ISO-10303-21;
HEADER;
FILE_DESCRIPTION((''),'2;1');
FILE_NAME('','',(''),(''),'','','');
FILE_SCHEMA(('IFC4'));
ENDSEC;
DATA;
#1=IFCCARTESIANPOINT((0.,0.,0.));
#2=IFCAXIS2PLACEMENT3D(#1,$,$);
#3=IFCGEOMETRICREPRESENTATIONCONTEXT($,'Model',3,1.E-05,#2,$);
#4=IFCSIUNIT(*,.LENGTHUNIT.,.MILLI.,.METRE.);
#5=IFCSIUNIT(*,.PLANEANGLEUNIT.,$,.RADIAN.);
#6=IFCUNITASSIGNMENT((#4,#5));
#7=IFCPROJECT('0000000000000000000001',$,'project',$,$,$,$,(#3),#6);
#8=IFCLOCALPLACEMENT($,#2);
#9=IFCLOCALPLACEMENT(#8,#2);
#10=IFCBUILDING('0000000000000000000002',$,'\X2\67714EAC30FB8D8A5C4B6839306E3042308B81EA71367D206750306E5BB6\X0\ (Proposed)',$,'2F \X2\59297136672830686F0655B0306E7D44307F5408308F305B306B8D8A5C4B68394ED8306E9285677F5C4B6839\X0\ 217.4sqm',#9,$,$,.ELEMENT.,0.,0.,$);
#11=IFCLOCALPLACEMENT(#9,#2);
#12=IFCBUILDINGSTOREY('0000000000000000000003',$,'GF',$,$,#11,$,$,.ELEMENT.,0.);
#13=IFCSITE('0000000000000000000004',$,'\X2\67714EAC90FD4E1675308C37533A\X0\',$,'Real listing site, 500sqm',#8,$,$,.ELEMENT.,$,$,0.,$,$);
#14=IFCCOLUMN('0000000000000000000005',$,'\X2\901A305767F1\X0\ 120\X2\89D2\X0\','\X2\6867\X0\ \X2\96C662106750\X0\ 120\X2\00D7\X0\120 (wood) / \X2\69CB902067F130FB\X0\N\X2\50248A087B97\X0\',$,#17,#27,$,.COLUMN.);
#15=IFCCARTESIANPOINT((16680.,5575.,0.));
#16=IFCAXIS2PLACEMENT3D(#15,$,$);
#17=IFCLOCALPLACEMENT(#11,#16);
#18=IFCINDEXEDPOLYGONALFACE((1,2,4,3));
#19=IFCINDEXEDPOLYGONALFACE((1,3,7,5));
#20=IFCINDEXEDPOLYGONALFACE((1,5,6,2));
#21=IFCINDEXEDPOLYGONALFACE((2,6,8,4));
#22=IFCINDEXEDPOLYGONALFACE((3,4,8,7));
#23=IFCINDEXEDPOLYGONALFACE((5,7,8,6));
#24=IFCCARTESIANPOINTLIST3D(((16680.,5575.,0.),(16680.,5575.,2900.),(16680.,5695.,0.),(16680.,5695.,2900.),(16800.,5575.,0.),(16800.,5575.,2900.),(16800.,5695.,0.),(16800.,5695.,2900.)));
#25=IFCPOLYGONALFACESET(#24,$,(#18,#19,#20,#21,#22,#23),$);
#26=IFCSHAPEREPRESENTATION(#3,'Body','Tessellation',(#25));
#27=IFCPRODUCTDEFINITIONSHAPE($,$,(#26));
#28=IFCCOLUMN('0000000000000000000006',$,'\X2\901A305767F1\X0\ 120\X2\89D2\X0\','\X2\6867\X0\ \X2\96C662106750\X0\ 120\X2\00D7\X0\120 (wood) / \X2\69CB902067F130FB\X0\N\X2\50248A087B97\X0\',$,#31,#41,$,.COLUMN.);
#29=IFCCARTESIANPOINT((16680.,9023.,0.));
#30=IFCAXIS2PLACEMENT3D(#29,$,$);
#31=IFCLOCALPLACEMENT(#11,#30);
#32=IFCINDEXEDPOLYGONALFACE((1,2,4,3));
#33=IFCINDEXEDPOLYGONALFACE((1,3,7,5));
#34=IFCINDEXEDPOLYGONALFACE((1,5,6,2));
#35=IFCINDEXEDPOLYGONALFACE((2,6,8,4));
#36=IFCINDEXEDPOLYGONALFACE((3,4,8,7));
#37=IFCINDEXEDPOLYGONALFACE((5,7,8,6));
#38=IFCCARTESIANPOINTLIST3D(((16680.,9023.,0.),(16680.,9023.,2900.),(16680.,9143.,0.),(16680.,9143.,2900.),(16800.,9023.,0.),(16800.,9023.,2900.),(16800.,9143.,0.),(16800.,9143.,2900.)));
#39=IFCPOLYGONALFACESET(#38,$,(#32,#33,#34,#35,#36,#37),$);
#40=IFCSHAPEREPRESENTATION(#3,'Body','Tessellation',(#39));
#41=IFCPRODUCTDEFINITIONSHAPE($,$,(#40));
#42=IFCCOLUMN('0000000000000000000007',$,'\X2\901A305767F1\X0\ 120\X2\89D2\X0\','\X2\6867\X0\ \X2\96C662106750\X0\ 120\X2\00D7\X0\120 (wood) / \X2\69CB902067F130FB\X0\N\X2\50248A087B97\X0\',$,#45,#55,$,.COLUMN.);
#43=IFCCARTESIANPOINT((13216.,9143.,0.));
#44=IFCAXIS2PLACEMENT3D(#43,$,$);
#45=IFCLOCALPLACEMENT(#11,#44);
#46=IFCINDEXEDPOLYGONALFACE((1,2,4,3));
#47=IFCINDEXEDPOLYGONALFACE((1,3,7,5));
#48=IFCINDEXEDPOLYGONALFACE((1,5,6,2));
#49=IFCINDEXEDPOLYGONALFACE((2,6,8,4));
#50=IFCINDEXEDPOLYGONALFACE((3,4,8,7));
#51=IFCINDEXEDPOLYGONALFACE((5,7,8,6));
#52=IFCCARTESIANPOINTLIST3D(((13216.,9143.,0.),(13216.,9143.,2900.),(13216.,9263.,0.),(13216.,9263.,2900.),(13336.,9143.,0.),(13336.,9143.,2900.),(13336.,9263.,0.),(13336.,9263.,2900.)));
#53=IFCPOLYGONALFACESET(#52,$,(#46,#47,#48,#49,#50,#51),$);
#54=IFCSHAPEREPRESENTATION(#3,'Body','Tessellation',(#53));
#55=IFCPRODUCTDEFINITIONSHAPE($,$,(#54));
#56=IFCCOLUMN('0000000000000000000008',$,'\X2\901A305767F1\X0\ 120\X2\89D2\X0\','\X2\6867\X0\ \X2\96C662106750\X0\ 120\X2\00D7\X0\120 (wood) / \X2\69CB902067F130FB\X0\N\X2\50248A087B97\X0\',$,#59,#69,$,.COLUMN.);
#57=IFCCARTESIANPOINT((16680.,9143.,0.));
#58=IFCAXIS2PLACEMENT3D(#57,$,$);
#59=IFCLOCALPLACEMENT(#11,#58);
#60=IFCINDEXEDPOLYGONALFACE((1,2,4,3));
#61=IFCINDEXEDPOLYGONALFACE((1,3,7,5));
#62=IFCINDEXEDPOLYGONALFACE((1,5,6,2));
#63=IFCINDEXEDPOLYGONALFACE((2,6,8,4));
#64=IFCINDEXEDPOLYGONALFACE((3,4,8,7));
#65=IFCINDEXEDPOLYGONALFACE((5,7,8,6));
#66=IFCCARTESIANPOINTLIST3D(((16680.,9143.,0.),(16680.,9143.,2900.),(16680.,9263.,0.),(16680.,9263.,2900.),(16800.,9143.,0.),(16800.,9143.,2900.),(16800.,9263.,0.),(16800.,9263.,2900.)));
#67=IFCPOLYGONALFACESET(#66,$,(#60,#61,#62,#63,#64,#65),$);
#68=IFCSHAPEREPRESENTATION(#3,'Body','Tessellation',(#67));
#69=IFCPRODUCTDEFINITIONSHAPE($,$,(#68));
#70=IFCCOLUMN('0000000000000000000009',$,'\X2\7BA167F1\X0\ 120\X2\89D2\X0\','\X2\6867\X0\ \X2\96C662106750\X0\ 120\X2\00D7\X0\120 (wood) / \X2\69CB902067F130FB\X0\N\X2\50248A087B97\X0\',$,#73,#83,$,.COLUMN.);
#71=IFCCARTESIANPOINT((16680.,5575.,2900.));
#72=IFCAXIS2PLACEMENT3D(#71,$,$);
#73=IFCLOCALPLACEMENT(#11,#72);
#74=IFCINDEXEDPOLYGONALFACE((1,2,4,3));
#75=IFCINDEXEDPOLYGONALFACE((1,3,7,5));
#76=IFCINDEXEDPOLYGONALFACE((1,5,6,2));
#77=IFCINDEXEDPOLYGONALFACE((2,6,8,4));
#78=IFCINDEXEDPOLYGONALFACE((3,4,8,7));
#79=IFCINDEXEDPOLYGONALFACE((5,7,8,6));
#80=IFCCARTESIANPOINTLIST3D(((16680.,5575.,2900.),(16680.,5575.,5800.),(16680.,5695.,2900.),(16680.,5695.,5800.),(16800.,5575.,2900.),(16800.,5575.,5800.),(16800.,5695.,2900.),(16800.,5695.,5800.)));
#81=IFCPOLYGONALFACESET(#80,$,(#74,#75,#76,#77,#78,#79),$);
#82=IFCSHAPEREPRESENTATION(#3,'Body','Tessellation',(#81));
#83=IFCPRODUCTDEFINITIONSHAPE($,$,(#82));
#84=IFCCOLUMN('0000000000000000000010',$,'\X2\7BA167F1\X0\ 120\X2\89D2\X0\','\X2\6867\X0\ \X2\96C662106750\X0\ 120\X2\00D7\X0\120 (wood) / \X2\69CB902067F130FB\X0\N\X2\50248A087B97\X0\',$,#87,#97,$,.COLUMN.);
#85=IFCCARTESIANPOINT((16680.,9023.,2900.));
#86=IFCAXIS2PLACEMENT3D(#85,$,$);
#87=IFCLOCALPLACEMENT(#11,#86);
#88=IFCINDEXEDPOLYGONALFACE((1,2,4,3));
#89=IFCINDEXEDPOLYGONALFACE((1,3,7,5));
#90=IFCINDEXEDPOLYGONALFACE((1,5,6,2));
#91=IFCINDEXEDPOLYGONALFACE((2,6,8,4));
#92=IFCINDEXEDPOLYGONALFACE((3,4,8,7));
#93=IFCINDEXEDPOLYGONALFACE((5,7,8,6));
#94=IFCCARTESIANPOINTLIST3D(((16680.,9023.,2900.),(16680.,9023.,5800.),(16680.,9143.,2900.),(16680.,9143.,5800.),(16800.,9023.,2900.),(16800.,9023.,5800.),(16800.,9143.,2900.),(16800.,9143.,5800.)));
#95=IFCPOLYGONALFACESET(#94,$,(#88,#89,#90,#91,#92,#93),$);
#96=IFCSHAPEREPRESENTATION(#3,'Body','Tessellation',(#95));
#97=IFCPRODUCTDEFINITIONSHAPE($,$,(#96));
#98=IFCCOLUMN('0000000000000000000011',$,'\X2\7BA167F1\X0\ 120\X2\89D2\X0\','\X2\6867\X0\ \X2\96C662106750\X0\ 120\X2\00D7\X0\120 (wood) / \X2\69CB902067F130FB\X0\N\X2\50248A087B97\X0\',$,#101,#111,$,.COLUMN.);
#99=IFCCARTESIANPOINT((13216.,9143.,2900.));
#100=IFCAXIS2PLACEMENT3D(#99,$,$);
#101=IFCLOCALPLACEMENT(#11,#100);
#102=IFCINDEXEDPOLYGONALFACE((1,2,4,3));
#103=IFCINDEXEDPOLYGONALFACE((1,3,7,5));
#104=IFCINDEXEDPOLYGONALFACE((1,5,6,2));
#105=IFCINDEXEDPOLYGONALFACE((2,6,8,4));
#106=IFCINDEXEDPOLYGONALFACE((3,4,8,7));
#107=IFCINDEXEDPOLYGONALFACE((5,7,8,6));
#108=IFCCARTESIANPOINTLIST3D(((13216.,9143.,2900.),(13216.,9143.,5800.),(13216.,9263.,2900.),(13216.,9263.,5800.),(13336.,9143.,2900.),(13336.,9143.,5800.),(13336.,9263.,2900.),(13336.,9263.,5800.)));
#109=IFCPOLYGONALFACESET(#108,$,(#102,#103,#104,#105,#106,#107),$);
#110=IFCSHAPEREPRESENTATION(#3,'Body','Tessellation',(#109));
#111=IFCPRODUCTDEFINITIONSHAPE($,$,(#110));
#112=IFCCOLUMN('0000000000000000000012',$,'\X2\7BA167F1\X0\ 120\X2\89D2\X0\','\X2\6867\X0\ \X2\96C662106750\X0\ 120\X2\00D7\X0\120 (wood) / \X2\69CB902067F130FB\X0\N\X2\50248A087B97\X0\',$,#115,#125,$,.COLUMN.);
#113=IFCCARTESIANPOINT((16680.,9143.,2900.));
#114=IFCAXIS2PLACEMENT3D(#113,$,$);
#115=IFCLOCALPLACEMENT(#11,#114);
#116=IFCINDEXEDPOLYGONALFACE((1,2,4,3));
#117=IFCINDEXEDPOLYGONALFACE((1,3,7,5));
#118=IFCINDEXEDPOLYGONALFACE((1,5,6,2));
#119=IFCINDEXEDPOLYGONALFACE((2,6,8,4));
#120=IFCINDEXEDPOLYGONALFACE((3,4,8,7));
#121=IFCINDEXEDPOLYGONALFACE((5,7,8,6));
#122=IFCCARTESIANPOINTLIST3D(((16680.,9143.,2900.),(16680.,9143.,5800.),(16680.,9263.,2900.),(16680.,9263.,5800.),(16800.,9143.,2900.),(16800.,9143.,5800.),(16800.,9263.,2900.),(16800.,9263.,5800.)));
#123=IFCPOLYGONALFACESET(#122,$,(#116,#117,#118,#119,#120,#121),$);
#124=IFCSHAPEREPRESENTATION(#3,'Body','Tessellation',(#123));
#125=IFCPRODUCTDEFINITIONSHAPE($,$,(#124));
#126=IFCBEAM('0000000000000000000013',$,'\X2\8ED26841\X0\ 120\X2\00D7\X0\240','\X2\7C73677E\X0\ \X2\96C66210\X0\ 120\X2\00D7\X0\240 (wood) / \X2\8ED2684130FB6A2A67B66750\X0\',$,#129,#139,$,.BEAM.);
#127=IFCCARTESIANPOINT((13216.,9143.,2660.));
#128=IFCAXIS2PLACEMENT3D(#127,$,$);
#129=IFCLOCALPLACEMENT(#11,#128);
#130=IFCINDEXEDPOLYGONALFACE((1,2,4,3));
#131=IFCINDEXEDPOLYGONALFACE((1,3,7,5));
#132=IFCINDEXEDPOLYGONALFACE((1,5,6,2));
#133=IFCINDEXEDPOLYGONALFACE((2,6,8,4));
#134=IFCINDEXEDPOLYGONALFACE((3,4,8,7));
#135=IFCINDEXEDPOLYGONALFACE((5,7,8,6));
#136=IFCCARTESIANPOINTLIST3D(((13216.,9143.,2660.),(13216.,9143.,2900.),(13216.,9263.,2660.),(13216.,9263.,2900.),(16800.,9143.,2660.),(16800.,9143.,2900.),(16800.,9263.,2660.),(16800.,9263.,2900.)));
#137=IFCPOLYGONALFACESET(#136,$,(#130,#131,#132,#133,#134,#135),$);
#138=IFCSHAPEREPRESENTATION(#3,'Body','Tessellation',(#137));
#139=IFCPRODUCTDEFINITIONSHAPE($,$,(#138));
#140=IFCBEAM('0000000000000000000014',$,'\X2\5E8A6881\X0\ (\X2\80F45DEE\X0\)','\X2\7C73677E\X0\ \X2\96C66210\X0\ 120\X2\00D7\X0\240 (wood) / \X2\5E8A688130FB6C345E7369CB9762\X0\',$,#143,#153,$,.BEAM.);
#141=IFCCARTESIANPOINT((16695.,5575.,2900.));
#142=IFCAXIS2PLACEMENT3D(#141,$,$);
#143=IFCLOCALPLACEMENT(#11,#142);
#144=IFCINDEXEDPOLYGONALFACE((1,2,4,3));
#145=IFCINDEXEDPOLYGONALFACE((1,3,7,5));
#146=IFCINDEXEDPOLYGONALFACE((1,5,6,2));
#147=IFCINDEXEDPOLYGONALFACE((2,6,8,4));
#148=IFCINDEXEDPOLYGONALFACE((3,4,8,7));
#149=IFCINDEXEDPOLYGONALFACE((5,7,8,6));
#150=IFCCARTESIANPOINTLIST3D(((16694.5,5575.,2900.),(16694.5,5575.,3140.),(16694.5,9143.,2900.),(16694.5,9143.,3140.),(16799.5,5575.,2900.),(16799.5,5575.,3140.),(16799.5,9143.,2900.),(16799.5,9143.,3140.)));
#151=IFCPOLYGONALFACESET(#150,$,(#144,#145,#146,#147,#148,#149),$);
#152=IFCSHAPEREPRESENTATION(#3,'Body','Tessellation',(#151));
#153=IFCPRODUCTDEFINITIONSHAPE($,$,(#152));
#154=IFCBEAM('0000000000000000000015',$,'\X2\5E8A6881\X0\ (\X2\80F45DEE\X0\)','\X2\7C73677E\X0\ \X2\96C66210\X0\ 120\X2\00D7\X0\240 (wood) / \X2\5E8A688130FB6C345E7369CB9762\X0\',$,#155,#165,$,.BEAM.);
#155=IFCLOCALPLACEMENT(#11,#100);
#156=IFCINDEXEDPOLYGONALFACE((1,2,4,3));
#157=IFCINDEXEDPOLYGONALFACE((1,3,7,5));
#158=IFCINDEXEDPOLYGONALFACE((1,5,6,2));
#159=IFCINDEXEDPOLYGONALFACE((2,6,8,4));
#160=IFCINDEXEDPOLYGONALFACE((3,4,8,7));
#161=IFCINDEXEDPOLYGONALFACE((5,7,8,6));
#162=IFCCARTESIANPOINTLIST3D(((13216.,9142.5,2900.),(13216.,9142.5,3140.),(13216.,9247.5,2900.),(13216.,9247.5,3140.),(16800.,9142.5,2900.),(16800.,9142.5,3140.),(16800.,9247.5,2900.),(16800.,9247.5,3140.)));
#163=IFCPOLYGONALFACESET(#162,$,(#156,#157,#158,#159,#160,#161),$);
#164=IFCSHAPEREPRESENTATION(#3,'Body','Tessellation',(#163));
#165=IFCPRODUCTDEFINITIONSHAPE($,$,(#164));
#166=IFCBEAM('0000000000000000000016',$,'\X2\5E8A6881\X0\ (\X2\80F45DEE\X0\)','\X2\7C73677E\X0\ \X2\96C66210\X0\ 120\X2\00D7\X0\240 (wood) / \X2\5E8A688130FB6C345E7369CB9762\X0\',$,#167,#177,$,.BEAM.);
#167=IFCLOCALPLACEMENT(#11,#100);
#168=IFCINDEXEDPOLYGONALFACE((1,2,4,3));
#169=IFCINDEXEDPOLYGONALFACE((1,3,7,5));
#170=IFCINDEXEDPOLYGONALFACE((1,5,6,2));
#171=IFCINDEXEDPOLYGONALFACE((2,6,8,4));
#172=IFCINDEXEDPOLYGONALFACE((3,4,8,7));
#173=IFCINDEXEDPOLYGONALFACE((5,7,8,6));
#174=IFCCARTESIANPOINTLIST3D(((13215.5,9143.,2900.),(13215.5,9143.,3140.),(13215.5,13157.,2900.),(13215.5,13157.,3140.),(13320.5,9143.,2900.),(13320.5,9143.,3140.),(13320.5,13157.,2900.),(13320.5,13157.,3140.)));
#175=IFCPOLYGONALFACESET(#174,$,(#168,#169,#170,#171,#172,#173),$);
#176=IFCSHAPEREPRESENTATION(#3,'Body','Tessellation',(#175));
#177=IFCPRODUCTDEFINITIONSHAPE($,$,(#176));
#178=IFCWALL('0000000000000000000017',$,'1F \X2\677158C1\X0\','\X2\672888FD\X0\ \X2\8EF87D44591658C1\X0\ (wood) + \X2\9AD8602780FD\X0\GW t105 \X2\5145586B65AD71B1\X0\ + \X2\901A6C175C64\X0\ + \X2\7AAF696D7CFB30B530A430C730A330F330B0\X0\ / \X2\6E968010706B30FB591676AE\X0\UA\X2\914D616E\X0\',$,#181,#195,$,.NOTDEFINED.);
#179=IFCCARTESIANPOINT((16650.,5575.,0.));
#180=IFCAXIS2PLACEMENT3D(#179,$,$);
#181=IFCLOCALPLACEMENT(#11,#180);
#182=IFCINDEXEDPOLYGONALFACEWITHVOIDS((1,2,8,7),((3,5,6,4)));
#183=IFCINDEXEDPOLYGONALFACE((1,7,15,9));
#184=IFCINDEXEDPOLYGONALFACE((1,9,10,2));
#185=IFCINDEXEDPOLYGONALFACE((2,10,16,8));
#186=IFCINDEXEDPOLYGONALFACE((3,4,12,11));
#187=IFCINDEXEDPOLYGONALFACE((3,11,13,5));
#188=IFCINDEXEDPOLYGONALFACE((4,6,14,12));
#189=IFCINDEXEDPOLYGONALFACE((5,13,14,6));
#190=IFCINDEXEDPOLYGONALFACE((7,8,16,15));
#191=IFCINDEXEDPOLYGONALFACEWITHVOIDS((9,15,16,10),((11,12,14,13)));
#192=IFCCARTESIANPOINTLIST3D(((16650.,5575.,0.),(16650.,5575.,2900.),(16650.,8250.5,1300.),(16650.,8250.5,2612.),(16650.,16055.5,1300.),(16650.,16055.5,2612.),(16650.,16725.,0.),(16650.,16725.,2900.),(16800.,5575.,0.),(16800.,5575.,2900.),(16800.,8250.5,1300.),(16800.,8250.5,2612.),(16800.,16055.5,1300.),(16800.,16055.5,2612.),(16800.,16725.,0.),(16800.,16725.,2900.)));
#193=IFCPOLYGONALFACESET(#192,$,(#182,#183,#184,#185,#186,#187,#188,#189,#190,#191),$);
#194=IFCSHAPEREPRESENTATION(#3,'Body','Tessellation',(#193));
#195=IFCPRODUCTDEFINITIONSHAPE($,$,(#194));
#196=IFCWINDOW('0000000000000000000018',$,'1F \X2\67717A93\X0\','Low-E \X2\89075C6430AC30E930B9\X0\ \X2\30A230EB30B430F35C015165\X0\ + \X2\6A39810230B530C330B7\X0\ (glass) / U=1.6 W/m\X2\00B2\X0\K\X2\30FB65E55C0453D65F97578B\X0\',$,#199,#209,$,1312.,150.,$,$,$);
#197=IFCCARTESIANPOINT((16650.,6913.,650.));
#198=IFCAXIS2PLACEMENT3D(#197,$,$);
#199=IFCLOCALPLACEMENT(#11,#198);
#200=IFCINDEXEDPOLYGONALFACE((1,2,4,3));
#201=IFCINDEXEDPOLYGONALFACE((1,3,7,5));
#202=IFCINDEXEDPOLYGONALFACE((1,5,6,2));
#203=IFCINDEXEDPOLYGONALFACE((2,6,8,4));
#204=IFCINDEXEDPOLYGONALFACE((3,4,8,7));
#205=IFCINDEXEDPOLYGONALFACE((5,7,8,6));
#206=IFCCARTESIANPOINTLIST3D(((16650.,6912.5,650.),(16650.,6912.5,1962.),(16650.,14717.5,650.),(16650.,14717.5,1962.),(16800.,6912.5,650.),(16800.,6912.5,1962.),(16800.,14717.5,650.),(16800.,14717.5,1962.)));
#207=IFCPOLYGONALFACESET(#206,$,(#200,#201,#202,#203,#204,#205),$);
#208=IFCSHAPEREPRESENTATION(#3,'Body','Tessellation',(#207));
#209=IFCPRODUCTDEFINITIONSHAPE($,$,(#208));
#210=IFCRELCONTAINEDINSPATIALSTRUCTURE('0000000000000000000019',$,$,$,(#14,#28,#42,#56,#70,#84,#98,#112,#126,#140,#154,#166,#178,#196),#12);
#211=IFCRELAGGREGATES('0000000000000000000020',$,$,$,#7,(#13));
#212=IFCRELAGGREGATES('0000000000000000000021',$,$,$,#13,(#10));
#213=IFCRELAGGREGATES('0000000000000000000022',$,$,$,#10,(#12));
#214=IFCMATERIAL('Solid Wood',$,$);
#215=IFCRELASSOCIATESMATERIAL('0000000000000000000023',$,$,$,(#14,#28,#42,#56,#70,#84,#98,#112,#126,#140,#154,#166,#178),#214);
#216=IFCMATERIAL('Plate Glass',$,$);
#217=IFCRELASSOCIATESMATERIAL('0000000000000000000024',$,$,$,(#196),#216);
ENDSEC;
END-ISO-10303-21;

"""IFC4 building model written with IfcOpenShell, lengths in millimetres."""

from ifc_helpers import new_model, si_unit, frame, frame_2d, origin, place, context, project, spatial, rectangle, extrude, material, element, fill, save


model = new_model("IFC4")

# Units and contexts
model_context = context("Model", 3, precision=1e-05, world=origin())
ifc_project = project(units=[si_unit("LENGTHUNIT", "METRE", prefix="MILLI"), si_unit("PLANEANGLEUNIT", "RADIAN")], contexts=[model_context])

# Site, building, storey
site_placement = place(None, origin())
site = spatial("IfcSite", under=ifc_project, at=site_placement, Name="東京都世田谷区", ObjectType="Real listing site, 500sqm", CompositionType="ELEMENT", RefElevation=0.0)
building_placement = place(site_placement, origin())
building = spatial("IfcBuilding", under=site, at=building_placement, Name="東京・越屋根のある自然素材の家 (Proposed)", ObjectType="2F 天然木と漆喰の組み合わせに越屋根付の銅板屋根 217.4sqm", CompositionType="ELEMENT", ElevationOfRefHeight=0.0, ElevationOfTerrain=0.0)
storey_placement = place(building_placement, origin())
storey = spatial("IfcBuildingStorey", under=building, at=storey_placement, Name="GF", CompositionType="ELEMENT", Elevation=0.0)

# Columns
ifc_material_1 = material(Name="Solid Wood")
column_1_placement = place(storey_placement, frame((16680.0, 5575.0, 0.0)))
element("IfcColumn", 1, at=column_1_placement, inside=storey, material=ifc_material_1, Name="通し柱 120角", Description="桧 集成材 120×120 (wood) / 構造柱・N値計算", PredefinedType="COLUMN", context=model_context, shape_type="SweptSolid", body=[
    extrude(rectangle(XDim=120.0, YDim=120.0, at=frame_2d((60.0, 60.0))), frame((16680.0, 5575.0, 0.0)), (0.0, 0.0, 1.0), 2900.0),
])
column_2_placement = place(storey_placement, frame((16680.0, 9023.0, 0.0)))
element("IfcColumn", 2, at=column_2_placement, inside=storey, material=ifc_material_1, Name="通し柱 120角", Description="桧 集成材 120×120 (wood) / 構造柱・N値計算", PredefinedType="COLUMN", context=model_context, shape_type="SweptSolid", body=[
    extrude(rectangle(XDim=120.0, YDim=120.0, at=frame_2d((60.0, 60.0))), frame((16680.0, 9023.0, 0.0)), (0.0, 0.0, 1.0), 2900.0),
])
column_3_placement = place(storey_placement, frame((13216.0, 9143.0, 0.0)))
element("IfcColumn", 3, at=column_3_placement, inside=storey, material=ifc_material_1, Name="通し柱 120角", Description="桧 集成材 120×120 (wood) / 構造柱・N値計算", PredefinedType="COLUMN", context=model_context, shape_type="SweptSolid", body=[
    extrude(rectangle(XDim=120.0, YDim=120.0, at=frame_2d((60.0, 60.0))), frame((13216.0, 9143.0, 0.0)), (0.0, 0.0, 1.0), 2900.0),
])
column_4_placement = place(storey_placement, frame((16680.0, 9143.0, 0.0)))
element("IfcColumn", 4, at=column_4_placement, inside=storey, material=ifc_material_1, Name="通し柱 120角", Description="桧 集成材 120×120 (wood) / 構造柱・N値計算", PredefinedType="COLUMN", context=model_context, shape_type="SweptSolid", body=[
    extrude(rectangle(XDim=120.0, YDim=120.0, at=frame_2d((60.0, 60.0))), frame((16680.0, 9143.0, 0.0)), (0.0, 0.0, 1.0), 2900.0),
])
column_5_placement = place(storey_placement, frame((16680.0, 5575.0, 2900.0)))
element("IfcColumn", 5, at=column_5_placement, inside=storey, material=ifc_material_1, Name="管柱 120角", Description="桧 集成材 120×120 (wood) / 構造柱・N値計算", PredefinedType="COLUMN", context=model_context, shape_type="SweptSolid", body=[
    extrude(rectangle(XDim=120.0, YDim=120.0, at=frame_2d((60.0, 60.0))), frame((16680.0, 5575.0, 2900.0)), (0.0, 0.0, 1.0), 2900.0),
])
column_6_placement = place(storey_placement, frame((16680.0, 9023.0, 2900.0)))
element("IfcColumn", 6, at=column_6_placement, inside=storey, material=ifc_material_1, Name="管柱 120角", Description="桧 集成材 120×120 (wood) / 構造柱・N値計算", PredefinedType="COLUMN", context=model_context, shape_type="SweptSolid", body=[
    extrude(rectangle(XDim=120.0, YDim=120.0, at=frame_2d((60.0, 60.0))), frame((16680.0, 9023.0, 2900.0)), (0.0, 0.0, 1.0), 2900.0),
])
column_7_placement = place(storey_placement, frame((13216.0, 9143.0, 2900.0)))
element("IfcColumn", 7, at=column_7_placement, inside=storey, material=ifc_material_1, Name="管柱 120角", Description="桧 集成材 120×120 (wood) / 構造柱・N値計算", PredefinedType="COLUMN", context=model_context, shape_type="SweptSolid", body=[
    extrude(rectangle(XDim=120.0, YDim=120.0, at=frame_2d((60.0, 60.0))), frame((13216.0, 9143.0, 2900.0)), (0.0, 0.0, 1.0), 2900.0),
])
column_8_placement = place(storey_placement, frame((16680.0, 9143.0, 2900.0)))
element("IfcColumn", 8, at=column_8_placement, inside=storey, material=ifc_material_1, Name="管柱 120角", Description="桧 集成材 120×120 (wood) / 構造柱・N値計算", PredefinedType="COLUMN", context=model_context, shape_type="SweptSolid", body=[
    extrude(rectangle(XDim=120.0, YDim=120.0, at=frame_2d((60.0, 60.0))), frame((16680.0, 9143.0, 2900.0)), (0.0, 0.0, 1.0), 2900.0),
])

# Beams
beam_1_placement = place(storey_placement, frame((13216.0, 9143.0, 2660.0)))
element("IfcBeam", 9, at=beam_1_placement, inside=storey, material=ifc_material_1, Name="軒桁 120×240", Description="米松 集成 120×240 (wood) / 軒桁・横架材", PredefinedType="BEAM", context=model_context, shape_type="SweptSolid", body=[
    extrude(rectangle(XDim=3584.0, YDim=120.0, at=frame_2d((1792.0, 60.0))), frame((13216.0, 9143.0, 2660.0)), (0.0, 0.0, 1.0), 240.0),
])
beam_2_placement = place(storey_placement, frame((16695.0, 5575.0, 2900.0)))
element("IfcBeam", 10, at=beam_2_placement, inside=storey, material=ifc_material_1, Name="床梁 (胴差)", Description="米松 集成 120×240 (wood) / 床梁・水平構面", PredefinedType="BEAM", context=model_context, shape_type="SweptSolid", body=[
    extrude(rectangle(XDim=105.0, YDim=3568.0, at=frame_2d((52.0, 1784.0))), frame((16695.0, 5575.0, 2900.0)), (0.0, 0.0, 1.0), 240.0),
])
beam_3_placement = place(storey_placement, frame((13216.0, 9143.0, 2900.0)))
element("IfcBeam", 11, at=beam_3_placement, inside=storey, material=ifc_material_1, Name="床梁 (胴差)", Description="米松 集成 120×240 (wood) / 床梁・水平構面", PredefinedType="BEAM", context=model_context, shape_type="SweptSolid", body=[
    extrude(rectangle(XDim=3584.0, YDim=105.0, at=frame_2d((1792.0, 52.0))), frame((13216.0, 9143.0, 2900.0)), (0.0, 0.0, 1.0), 240.0),
])
beam_4_placement = place(storey_placement, frame((13216.0, 9143.0, 2900.0)))
element("IfcBeam", 12, at=beam_4_placement, inside=storey, material=ifc_material_1, Name="床梁 (胴差)", Description="米松 集成 120×240 (wood) / 床梁・水平構面", PredefinedType="BEAM", context=model_context, shape_type="SweptSolid", body=[
    extrude(rectangle(XDim=105.0, YDim=4014.0, at=frame_2d((52.0, 2007.0))), frame((13216.0, 9143.0, 2900.0)), (0.0, 0.0, 1.0), 240.0),
])

# Wall, opening, window
wall_1_placement = place(storey_placement, frame((16650.0, 5575.0, 0.0)))
wall_1 = element("IfcWall", 13, at=wall_1_placement, inside=storey, material=ifc_material_1, Name="1F 東壁", Description="木製 軸組外壁 (wood) + 高性能GW t105 充填断熱 + 通気層 + 窯業系サイディング / 準耐火・外皮UA配慮", PredefinedType="NOTDEFINED", context=model_context, shape_type="SweptSolid", body=[
    extrude(rectangle(XDim=150.0, YDim=11150.0, at=frame_2d((75.0, 5575.0))), frame((16650.0, 5575.0, 0.0)), (0.0, 0.0, 1.0), 2900.0),
])
opening_1_placement = place(storey_placement, frame((16650.0, 6913.0, 650.0)))
opening_1 = element("IfcOpeningElement", 14, at=opening_1_placement, cuts=wall_1, PredefinedType="NOTDEFINED", context=model_context, shape_type="SweptSolid", body=[
    extrude(rectangle(XDim=150.0, YDim=7805.0, at=frame_2d((75.0, 3902.0))), frame((16650.0, 6913.0, 650.0)), (0.0, 0.0, 1.0), 1312.0),
])
ifc_material_2 = material(Name="Plate Glass")
window_1_placement = place(storey_placement, frame((16650.0, 6913.0, 650.0)))
window_1 = element("IfcWindow", 15, at=window_1_placement, inside=storey, material=ifc_material_2, Name="1F 東窓", Description="Low-E 複層ガラス アルゴン封入 + 樹脂サッシ (glass) / U=1.6 W/m²K・日射取得型", OverallHeight=1312.0, OverallWidth=150.0, context=model_context, shape_type="SweptSolid", body=[
    extrude(rectangle(XDim=150.0, YDim=7805.0, at=frame_2d((75.0, 3902.0))), frame((16650.0, 6913.0, 650.0)), (0.0, 0.0, 1.0), 1312.0),
])
fill(opening_1, window_1)

save(model, "model.ifc")
